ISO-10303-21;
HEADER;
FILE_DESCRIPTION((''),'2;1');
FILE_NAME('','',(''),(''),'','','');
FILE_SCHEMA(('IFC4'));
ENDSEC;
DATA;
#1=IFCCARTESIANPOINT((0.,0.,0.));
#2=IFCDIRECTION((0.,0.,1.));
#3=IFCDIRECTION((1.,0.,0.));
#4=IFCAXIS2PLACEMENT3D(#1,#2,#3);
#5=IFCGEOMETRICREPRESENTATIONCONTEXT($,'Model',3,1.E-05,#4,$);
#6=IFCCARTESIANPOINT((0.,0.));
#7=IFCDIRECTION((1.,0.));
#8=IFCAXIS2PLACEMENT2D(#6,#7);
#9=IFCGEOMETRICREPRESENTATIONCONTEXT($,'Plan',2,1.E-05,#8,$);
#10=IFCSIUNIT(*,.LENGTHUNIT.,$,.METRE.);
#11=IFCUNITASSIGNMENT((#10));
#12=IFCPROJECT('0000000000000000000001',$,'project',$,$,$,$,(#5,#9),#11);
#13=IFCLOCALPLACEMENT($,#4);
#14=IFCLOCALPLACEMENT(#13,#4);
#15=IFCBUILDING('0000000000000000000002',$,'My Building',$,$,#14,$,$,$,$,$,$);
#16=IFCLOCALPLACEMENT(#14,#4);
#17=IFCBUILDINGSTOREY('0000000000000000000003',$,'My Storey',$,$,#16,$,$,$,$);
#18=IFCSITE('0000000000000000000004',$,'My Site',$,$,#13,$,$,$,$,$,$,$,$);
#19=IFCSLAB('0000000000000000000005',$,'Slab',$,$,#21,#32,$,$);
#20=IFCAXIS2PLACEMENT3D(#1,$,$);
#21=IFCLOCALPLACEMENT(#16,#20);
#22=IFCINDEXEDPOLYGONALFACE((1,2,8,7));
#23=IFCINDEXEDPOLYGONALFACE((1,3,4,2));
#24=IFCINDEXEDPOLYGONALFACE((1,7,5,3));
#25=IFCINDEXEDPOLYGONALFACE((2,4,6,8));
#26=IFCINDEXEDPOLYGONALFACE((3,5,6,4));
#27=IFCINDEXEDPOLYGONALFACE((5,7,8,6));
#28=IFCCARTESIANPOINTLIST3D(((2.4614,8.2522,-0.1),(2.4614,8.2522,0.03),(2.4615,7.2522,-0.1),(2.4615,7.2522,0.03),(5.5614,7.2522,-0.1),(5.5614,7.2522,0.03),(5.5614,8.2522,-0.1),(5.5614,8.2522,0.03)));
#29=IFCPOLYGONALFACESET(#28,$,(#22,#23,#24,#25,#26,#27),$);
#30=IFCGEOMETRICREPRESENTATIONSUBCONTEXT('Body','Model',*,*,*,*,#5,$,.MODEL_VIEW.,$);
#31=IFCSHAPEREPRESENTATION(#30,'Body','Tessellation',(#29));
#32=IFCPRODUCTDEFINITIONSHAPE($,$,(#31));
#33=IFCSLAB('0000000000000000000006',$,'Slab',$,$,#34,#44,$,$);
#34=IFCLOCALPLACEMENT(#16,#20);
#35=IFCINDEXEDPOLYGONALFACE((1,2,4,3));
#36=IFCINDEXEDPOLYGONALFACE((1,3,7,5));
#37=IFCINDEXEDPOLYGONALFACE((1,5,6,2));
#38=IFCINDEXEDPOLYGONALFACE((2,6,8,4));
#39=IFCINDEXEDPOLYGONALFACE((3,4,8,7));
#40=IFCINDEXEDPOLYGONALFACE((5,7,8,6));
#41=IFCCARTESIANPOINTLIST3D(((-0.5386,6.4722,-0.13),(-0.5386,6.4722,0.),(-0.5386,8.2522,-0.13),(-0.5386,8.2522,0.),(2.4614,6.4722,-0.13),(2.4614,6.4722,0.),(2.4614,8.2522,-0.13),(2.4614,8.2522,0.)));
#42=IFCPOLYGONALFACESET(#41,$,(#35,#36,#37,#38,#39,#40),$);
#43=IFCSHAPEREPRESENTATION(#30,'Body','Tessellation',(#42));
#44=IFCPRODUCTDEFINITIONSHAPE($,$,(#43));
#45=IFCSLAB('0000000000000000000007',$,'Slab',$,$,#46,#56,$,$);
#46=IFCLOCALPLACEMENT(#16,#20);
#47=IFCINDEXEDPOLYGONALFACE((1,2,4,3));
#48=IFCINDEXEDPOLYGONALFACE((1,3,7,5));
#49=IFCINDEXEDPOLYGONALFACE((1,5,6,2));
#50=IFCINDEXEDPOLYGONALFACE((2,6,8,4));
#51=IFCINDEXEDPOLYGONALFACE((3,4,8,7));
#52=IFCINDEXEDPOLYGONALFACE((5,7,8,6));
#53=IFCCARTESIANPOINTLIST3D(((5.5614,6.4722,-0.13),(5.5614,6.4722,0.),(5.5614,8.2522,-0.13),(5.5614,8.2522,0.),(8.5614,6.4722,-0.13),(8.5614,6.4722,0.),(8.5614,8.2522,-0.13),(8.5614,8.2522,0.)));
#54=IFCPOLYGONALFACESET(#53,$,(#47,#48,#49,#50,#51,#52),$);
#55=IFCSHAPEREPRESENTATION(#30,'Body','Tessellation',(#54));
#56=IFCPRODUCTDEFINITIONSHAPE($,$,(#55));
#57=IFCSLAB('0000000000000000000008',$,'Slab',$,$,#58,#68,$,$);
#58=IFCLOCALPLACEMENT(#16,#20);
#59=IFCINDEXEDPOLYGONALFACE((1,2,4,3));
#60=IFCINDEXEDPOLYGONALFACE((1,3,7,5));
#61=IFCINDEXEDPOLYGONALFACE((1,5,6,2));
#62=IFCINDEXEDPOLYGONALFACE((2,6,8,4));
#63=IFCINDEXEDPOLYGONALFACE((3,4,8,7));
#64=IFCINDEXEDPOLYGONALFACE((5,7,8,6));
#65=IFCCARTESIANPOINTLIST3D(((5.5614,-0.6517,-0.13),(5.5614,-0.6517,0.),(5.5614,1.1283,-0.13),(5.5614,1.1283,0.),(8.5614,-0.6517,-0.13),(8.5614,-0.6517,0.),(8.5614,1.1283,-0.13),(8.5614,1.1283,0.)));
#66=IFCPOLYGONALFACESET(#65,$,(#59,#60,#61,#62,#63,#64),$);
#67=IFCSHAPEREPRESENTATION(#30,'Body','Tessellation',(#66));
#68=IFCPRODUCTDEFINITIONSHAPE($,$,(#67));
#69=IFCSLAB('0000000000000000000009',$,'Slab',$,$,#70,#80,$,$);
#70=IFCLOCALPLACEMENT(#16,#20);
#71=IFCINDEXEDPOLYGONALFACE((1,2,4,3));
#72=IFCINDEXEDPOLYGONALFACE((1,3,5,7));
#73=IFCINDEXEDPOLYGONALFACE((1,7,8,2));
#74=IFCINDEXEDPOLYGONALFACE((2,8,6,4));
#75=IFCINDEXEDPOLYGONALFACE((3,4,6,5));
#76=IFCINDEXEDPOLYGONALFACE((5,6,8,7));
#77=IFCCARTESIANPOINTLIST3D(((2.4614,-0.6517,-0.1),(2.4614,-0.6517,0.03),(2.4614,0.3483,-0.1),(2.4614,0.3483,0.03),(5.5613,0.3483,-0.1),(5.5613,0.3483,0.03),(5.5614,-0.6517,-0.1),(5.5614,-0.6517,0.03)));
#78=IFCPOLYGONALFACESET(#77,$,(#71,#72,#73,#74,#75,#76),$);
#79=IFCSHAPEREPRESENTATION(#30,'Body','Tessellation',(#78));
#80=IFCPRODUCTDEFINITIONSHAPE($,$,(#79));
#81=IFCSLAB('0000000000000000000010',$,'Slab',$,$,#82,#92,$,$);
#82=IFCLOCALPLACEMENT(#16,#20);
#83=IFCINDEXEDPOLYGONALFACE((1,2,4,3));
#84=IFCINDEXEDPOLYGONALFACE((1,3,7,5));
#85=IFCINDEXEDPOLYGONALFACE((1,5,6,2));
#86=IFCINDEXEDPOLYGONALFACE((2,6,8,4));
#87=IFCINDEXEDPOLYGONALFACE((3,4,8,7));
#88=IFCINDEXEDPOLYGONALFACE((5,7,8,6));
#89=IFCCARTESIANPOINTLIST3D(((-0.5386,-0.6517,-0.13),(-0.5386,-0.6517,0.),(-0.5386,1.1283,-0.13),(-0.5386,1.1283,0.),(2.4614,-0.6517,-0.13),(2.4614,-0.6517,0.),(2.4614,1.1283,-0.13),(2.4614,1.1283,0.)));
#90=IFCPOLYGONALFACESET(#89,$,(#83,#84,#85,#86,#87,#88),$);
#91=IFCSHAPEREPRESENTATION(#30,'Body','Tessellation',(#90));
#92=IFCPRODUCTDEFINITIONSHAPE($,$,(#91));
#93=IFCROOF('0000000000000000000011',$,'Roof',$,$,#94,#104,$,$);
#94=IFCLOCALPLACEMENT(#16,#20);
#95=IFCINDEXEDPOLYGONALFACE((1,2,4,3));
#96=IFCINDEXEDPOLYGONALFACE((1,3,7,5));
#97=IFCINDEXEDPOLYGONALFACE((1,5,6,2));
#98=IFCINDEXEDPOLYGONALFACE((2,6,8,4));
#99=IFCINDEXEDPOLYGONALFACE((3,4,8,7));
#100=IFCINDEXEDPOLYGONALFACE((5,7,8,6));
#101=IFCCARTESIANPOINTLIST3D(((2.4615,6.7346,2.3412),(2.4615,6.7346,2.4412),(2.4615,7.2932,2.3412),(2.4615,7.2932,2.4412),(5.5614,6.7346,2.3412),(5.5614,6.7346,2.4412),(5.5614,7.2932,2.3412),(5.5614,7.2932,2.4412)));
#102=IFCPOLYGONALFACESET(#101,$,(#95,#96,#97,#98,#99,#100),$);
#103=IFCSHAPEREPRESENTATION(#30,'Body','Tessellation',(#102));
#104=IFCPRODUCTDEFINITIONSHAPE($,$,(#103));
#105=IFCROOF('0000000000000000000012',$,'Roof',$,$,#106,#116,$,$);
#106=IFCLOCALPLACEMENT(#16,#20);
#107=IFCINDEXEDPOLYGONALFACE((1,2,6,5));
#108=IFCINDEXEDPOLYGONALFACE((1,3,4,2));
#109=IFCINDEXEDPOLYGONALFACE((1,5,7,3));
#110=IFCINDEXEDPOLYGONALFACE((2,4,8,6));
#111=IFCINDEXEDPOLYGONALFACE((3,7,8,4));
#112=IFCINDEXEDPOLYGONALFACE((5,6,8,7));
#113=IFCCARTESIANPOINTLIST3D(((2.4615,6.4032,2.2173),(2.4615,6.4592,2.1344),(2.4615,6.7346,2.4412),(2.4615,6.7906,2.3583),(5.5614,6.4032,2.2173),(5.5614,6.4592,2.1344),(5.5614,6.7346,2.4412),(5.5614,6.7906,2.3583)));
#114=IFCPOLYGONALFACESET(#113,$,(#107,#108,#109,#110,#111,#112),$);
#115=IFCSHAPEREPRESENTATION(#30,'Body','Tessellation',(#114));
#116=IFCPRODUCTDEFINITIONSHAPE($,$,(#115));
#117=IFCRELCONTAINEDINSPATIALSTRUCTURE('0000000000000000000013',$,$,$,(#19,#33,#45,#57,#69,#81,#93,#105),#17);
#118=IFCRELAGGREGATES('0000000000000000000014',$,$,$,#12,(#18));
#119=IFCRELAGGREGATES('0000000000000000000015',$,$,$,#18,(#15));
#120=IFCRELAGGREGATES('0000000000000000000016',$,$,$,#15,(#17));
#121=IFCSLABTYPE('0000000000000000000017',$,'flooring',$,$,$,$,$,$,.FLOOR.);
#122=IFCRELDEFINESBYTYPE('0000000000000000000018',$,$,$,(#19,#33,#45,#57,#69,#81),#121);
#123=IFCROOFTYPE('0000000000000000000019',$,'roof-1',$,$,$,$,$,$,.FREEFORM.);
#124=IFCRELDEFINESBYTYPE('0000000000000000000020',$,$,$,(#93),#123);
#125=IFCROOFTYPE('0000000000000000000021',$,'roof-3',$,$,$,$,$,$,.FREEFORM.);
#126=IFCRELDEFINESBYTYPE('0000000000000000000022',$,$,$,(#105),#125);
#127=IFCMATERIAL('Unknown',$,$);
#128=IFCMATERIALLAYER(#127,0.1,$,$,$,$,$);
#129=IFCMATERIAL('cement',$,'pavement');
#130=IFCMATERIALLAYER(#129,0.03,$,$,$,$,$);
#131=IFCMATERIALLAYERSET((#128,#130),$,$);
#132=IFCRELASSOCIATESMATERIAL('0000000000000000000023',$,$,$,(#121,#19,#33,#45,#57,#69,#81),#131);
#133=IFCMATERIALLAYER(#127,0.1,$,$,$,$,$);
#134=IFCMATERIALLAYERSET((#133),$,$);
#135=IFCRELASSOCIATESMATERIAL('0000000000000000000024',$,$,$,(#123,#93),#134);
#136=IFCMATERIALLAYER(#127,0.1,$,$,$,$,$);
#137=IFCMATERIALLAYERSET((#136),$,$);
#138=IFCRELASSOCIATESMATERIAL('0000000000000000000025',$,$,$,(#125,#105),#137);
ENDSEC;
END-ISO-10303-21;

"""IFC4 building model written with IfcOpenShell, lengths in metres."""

from ifc_helpers import new_model, si_unit, frame, origin_with_axes, origin_2d_with_axis, place, context, subcontext, project, spatial, indexed_curve, outline, extrude, material, layer, layer_set, layer_usage, type_object, element, save


model = new_model("IFC4")

# Units and contexts
model_context = context("Model", 3, precision=1e-05, world=origin_with_axes())
plan_context = context("Plan", 2, precision=1e-05, world=origin_2d_with_axis())
body_context = subcontext(model_context, "Body", "Model", "MODEL_VIEW")
ifc_project = project(units=[si_unit("LENGTHUNIT", "METRE")], contexts=[model_context, plan_context])

# Site, building, storey
site_placement = place(None, origin_with_axes())
site = spatial("IfcSite", under=ifc_project, at=site_placement, Name="My Site")
building_placement = place(site_placement, origin_with_axes())
building = spatial("IfcBuilding", under=site, at=building_placement, Name="My Building")
storey_placement = place(building_placement, origin_with_axes())
storey = spatial("IfcBuildingStorey", under=building, at=storey_placement, Name="My Storey")

# Shared definitions
ifc_material_1 = material(Name="Unknown")

# Slabs
ifc_layer_1 = layer(ifc_material_1, 0.1)
ifc_material_2 = material(Name="cement", Category="pavement")
ifc_layer_2 = layer(ifc_material_2, 0.03)
ifc_layer_set_1 = layer_set([ifc_layer_1, ifc_layer_2])
ifc_layer_usage_1 = layer_usage(ifc_layer_set_1, "AXIS3", "POSITIVE", -0.1)
slab_type_1 = type_object("IfcSlabType", Name="flooring", PredefinedType="FLOOR", material=ifc_layer_set_1)
slab_1_placement = place(storey_placement, frame((2.4615, 7.2522, 0.0), z_axis=(0.0, 0.0, 1.0), x_axis=(0.0, 1.0, 0.0)))
element("IfcSlab", 1, at=slab_1_placement, inside=storey, type_object=slab_type_1, material=ifc_layer_usage_1, Name="Slab", context=body_context, shape_type="SweptSolid", body=[
    extrude(outline(indexed_curve([(0.0, 0.0), (1.0, 0.0001), (1.0, -3.0999), (0.0, -3.0999), (0.0, 0.0)])), frame((0.0, 0.0, -0.1), z_axis=(0.0, 0.0, 1.0), x_axis=(1.0, 0.0, 0.0)), (0.0, 0.0, 1.0), 0.13),
])
ifc_layer_usage_2 = layer_usage(ifc_layer_set_1, "AXIS3", "POSITIVE", -0.13)
slab_2_placement = place(storey_placement, frame((2.4614, 8.2522, 0.0), z_axis=(0.0, 0.0, 1.0), x_axis=(0.0, 1.0, 0.0)))
element("IfcSlab", 2, at=slab_2_placement, inside=storey, type_object=slab_type_1, material=ifc_layer_usage_2, Name="Slab", context=body_context, shape_type="SweptSolid", body=[
    extrude(outline(indexed_curve([(0.0, 0.0), (-1.78, 0.0), (-1.78, 3.0), (0.0, 3.0), (0.0, 0.0)])), frame((0.0, 0.0, -0.13), z_axis=(0.0, 0.0, 1.0), x_axis=(1.0, 0.0, 0.0)), (0.0, 0.0, 1.0), 0.13),
])
ifc_layer_usage_3 = layer_usage(ifc_layer_set_1, "AXIS3", "POSITIVE", -0.13)
slab_3_placement = place(storey_placement, frame((8.5614, 8.2522, 0.0), z_axis=(0.0, 0.0, 1.0), x_axis=(0.0, 1.0, 0.0)))
element("IfcSlab", 3, at=slab_3_placement, inside=storey, type_object=slab_type_1, material=ifc_layer_usage_3, Name="Slab", context=body_context, shape_type="SweptSolid", body=[
    extrude(outline(indexed_curve([(0.0, 0.0), (-1.78, 0.0), (-1.78, 3.0), (0.0, 3.0), (0.0, 0.0)])), frame((0.0, 0.0, -0.13), z_axis=(0.0, 0.0, 1.0), x_axis=(1.0, 0.0, 0.0)), (0.0, 0.0, 1.0), 0.13),
])
ifc_layer_usage_4 = layer_usage(ifc_layer_set_1, "AXIS3", "POSITIVE", -0.13)
slab_4_placement = place(storey_placement, frame((5.5614, -0.6517, 0.0), z_axis=(0.0, 0.0, 1.0), x_axis=(0.0, -1.0, 0.0)))
element("IfcSlab", 4, at=slab_4_placement, inside=storey, type_object=slab_type_1, material=ifc_layer_usage_4, Name="Slab", context=body_context, shape_type="SweptSolid", body=[
    extrude(outline(indexed_curve([(0.0, 0.0), (-1.78, 0.0), (-1.78, 3.0), (0.0, 3.0), (0.0, 0.0)])), frame((0.0, 0.0, -0.13), z_axis=(0.0, 0.0, 1.0), x_axis=(1.0, 0.0, 0.0)), (0.0, 0.0, 1.0), 0.13),
])
ifc_layer_usage_5 = layer_usage(ifc_layer_set_1, "AXIS3", "POSITIVE", -0.1)
slab_5_placement = place(storey_placement, frame((5.5613, 0.3483, 0.0), z_axis=(0.0, 0.0, 1.0), x_axis=(0.0, -1.0, 0.0)))
element("IfcSlab", 5, at=slab_5_placement, inside=storey, type_object=slab_type_1, material=ifc_layer_usage_5, Name="Slab", context=body_context, shape_type="SweptSolid", body=[
    extrude(outline(indexed_curve([(0.0, 0.0), (1.0, 0.0001), (1.0, -3.0999), (0.0, -3.0999), (0.0, 0.0)])), frame((0.0, 0.0, -0.1), z_axis=(0.0, 0.0, 1.0), x_axis=(1.0, 0.0, 0.0)), (0.0, 0.0, 1.0), 0.13),
])
ifc_layer_usage_6 = layer_usage(ifc_layer_set_1, "AXIS3", "POSITIVE", -0.13)
slab_6_placement = place(storey_placement, frame((-0.5386, -0.6517, 0.0), z_axis=(0.0, 0.0, 1.0), x_axis=(0.0, -1.0, 0.0)))
element("IfcSlab", 6, at=slab_6_placement, inside=storey, type_object=slab_type_1, material=ifc_layer_usage_6, Name="Slab", context=body_context, shape_type="SweptSolid", body=[
    extrude(outline(indexed_curve([(0.0, 0.0), (-1.78, 0.0), (-1.78, 3.0), (0.0, 3.0), (0.0, 0.0)])), frame((0.0, 0.0, -0.13), z_axis=(0.0, 0.0, 1.0), x_axis=(1.0, 0.0, 0.0)), (0.0, 0.0, 1.0), 0.13),
])

# Roofs
ifc_layer_3 = layer(ifc_material_1, 0.1)
ifc_layer_set_2 = layer_set([ifc_layer_3])
ifc_layer_usage_7 = layer_usage(ifc_layer_set_2, "AXIS3", "POSITIVE", -0.1)
roof_type_1 = type_object("IfcRoofType", Name="roof-1", PredefinedType="FREEFORM", material=ifc_layer_set_2)
roof_1_placement = place(storey_placement, frame((2.4615, 7.2932, 2.4412), z_axis=(0.0, 0.0, 1.0), x_axis=(0.0, 1.0, 0.0)))
element("IfcRoof", 7, at=roof_1_placement, inside=storey, type_object=roof_type_1, material=ifc_layer_usage_7, Name="Roof", context=body_context, shape_type="SweptSolid", body=[
    extrude(outline(indexed_curve([(0.0, 0.0), (-0.5586, 0.0), (-0.5586, -3.0999), (0.0, -3.0999), (0.0, 0.0)])), frame((0.0, 0.0, -0.1), z_axis=(0.0, 0.0, 1.0), x_axis=(1.0, 0.0, 0.0)), (0.0, 0.0, 1.0), 0.1),
])
ifc_layer_4 = layer(ifc_material_1, 0.1)
ifc_layer_set_3 = layer_set([ifc_layer_4])
ifc_layer_usage_8 = layer_usage(ifc_layer_set_3, "AXIS3", "POSITIVE", -0.1)
roof_type_2 = type_object("IfcRoofType", Name="roof-3", PredefinedType="FREEFORM", material=ifc_layer_set_3)
roof_2_placement = place(storey_placement, frame((2.4615, 6.7346, 2.4412), z_axis=(0.0, -0.559823, 0.828612), x_axis=(0.0, 0.828612, 0.559823)))
element("IfcRoof", 8, at=roof_2_placement, inside=storey, type_object=roof_type_2, material=ifc_layer_usage_8, Name="Roof", context=body_context, shape_type="SweptSolid", body=[
    extrude(outline(indexed_curve([(0.0, 0.0), (0.0, -3.0999), (-0.4, -3.0999), (-0.4, 0.0), (0.0, 0.0)])), frame((0.0, 0.0, -0.1), z_axis=(0.0, 0.0, 1.0), x_axis=(1.0, 0.0, 0.0)), (0.0, 0.0, 1.0), 0.1),
])

save(model, "model.ifc")
